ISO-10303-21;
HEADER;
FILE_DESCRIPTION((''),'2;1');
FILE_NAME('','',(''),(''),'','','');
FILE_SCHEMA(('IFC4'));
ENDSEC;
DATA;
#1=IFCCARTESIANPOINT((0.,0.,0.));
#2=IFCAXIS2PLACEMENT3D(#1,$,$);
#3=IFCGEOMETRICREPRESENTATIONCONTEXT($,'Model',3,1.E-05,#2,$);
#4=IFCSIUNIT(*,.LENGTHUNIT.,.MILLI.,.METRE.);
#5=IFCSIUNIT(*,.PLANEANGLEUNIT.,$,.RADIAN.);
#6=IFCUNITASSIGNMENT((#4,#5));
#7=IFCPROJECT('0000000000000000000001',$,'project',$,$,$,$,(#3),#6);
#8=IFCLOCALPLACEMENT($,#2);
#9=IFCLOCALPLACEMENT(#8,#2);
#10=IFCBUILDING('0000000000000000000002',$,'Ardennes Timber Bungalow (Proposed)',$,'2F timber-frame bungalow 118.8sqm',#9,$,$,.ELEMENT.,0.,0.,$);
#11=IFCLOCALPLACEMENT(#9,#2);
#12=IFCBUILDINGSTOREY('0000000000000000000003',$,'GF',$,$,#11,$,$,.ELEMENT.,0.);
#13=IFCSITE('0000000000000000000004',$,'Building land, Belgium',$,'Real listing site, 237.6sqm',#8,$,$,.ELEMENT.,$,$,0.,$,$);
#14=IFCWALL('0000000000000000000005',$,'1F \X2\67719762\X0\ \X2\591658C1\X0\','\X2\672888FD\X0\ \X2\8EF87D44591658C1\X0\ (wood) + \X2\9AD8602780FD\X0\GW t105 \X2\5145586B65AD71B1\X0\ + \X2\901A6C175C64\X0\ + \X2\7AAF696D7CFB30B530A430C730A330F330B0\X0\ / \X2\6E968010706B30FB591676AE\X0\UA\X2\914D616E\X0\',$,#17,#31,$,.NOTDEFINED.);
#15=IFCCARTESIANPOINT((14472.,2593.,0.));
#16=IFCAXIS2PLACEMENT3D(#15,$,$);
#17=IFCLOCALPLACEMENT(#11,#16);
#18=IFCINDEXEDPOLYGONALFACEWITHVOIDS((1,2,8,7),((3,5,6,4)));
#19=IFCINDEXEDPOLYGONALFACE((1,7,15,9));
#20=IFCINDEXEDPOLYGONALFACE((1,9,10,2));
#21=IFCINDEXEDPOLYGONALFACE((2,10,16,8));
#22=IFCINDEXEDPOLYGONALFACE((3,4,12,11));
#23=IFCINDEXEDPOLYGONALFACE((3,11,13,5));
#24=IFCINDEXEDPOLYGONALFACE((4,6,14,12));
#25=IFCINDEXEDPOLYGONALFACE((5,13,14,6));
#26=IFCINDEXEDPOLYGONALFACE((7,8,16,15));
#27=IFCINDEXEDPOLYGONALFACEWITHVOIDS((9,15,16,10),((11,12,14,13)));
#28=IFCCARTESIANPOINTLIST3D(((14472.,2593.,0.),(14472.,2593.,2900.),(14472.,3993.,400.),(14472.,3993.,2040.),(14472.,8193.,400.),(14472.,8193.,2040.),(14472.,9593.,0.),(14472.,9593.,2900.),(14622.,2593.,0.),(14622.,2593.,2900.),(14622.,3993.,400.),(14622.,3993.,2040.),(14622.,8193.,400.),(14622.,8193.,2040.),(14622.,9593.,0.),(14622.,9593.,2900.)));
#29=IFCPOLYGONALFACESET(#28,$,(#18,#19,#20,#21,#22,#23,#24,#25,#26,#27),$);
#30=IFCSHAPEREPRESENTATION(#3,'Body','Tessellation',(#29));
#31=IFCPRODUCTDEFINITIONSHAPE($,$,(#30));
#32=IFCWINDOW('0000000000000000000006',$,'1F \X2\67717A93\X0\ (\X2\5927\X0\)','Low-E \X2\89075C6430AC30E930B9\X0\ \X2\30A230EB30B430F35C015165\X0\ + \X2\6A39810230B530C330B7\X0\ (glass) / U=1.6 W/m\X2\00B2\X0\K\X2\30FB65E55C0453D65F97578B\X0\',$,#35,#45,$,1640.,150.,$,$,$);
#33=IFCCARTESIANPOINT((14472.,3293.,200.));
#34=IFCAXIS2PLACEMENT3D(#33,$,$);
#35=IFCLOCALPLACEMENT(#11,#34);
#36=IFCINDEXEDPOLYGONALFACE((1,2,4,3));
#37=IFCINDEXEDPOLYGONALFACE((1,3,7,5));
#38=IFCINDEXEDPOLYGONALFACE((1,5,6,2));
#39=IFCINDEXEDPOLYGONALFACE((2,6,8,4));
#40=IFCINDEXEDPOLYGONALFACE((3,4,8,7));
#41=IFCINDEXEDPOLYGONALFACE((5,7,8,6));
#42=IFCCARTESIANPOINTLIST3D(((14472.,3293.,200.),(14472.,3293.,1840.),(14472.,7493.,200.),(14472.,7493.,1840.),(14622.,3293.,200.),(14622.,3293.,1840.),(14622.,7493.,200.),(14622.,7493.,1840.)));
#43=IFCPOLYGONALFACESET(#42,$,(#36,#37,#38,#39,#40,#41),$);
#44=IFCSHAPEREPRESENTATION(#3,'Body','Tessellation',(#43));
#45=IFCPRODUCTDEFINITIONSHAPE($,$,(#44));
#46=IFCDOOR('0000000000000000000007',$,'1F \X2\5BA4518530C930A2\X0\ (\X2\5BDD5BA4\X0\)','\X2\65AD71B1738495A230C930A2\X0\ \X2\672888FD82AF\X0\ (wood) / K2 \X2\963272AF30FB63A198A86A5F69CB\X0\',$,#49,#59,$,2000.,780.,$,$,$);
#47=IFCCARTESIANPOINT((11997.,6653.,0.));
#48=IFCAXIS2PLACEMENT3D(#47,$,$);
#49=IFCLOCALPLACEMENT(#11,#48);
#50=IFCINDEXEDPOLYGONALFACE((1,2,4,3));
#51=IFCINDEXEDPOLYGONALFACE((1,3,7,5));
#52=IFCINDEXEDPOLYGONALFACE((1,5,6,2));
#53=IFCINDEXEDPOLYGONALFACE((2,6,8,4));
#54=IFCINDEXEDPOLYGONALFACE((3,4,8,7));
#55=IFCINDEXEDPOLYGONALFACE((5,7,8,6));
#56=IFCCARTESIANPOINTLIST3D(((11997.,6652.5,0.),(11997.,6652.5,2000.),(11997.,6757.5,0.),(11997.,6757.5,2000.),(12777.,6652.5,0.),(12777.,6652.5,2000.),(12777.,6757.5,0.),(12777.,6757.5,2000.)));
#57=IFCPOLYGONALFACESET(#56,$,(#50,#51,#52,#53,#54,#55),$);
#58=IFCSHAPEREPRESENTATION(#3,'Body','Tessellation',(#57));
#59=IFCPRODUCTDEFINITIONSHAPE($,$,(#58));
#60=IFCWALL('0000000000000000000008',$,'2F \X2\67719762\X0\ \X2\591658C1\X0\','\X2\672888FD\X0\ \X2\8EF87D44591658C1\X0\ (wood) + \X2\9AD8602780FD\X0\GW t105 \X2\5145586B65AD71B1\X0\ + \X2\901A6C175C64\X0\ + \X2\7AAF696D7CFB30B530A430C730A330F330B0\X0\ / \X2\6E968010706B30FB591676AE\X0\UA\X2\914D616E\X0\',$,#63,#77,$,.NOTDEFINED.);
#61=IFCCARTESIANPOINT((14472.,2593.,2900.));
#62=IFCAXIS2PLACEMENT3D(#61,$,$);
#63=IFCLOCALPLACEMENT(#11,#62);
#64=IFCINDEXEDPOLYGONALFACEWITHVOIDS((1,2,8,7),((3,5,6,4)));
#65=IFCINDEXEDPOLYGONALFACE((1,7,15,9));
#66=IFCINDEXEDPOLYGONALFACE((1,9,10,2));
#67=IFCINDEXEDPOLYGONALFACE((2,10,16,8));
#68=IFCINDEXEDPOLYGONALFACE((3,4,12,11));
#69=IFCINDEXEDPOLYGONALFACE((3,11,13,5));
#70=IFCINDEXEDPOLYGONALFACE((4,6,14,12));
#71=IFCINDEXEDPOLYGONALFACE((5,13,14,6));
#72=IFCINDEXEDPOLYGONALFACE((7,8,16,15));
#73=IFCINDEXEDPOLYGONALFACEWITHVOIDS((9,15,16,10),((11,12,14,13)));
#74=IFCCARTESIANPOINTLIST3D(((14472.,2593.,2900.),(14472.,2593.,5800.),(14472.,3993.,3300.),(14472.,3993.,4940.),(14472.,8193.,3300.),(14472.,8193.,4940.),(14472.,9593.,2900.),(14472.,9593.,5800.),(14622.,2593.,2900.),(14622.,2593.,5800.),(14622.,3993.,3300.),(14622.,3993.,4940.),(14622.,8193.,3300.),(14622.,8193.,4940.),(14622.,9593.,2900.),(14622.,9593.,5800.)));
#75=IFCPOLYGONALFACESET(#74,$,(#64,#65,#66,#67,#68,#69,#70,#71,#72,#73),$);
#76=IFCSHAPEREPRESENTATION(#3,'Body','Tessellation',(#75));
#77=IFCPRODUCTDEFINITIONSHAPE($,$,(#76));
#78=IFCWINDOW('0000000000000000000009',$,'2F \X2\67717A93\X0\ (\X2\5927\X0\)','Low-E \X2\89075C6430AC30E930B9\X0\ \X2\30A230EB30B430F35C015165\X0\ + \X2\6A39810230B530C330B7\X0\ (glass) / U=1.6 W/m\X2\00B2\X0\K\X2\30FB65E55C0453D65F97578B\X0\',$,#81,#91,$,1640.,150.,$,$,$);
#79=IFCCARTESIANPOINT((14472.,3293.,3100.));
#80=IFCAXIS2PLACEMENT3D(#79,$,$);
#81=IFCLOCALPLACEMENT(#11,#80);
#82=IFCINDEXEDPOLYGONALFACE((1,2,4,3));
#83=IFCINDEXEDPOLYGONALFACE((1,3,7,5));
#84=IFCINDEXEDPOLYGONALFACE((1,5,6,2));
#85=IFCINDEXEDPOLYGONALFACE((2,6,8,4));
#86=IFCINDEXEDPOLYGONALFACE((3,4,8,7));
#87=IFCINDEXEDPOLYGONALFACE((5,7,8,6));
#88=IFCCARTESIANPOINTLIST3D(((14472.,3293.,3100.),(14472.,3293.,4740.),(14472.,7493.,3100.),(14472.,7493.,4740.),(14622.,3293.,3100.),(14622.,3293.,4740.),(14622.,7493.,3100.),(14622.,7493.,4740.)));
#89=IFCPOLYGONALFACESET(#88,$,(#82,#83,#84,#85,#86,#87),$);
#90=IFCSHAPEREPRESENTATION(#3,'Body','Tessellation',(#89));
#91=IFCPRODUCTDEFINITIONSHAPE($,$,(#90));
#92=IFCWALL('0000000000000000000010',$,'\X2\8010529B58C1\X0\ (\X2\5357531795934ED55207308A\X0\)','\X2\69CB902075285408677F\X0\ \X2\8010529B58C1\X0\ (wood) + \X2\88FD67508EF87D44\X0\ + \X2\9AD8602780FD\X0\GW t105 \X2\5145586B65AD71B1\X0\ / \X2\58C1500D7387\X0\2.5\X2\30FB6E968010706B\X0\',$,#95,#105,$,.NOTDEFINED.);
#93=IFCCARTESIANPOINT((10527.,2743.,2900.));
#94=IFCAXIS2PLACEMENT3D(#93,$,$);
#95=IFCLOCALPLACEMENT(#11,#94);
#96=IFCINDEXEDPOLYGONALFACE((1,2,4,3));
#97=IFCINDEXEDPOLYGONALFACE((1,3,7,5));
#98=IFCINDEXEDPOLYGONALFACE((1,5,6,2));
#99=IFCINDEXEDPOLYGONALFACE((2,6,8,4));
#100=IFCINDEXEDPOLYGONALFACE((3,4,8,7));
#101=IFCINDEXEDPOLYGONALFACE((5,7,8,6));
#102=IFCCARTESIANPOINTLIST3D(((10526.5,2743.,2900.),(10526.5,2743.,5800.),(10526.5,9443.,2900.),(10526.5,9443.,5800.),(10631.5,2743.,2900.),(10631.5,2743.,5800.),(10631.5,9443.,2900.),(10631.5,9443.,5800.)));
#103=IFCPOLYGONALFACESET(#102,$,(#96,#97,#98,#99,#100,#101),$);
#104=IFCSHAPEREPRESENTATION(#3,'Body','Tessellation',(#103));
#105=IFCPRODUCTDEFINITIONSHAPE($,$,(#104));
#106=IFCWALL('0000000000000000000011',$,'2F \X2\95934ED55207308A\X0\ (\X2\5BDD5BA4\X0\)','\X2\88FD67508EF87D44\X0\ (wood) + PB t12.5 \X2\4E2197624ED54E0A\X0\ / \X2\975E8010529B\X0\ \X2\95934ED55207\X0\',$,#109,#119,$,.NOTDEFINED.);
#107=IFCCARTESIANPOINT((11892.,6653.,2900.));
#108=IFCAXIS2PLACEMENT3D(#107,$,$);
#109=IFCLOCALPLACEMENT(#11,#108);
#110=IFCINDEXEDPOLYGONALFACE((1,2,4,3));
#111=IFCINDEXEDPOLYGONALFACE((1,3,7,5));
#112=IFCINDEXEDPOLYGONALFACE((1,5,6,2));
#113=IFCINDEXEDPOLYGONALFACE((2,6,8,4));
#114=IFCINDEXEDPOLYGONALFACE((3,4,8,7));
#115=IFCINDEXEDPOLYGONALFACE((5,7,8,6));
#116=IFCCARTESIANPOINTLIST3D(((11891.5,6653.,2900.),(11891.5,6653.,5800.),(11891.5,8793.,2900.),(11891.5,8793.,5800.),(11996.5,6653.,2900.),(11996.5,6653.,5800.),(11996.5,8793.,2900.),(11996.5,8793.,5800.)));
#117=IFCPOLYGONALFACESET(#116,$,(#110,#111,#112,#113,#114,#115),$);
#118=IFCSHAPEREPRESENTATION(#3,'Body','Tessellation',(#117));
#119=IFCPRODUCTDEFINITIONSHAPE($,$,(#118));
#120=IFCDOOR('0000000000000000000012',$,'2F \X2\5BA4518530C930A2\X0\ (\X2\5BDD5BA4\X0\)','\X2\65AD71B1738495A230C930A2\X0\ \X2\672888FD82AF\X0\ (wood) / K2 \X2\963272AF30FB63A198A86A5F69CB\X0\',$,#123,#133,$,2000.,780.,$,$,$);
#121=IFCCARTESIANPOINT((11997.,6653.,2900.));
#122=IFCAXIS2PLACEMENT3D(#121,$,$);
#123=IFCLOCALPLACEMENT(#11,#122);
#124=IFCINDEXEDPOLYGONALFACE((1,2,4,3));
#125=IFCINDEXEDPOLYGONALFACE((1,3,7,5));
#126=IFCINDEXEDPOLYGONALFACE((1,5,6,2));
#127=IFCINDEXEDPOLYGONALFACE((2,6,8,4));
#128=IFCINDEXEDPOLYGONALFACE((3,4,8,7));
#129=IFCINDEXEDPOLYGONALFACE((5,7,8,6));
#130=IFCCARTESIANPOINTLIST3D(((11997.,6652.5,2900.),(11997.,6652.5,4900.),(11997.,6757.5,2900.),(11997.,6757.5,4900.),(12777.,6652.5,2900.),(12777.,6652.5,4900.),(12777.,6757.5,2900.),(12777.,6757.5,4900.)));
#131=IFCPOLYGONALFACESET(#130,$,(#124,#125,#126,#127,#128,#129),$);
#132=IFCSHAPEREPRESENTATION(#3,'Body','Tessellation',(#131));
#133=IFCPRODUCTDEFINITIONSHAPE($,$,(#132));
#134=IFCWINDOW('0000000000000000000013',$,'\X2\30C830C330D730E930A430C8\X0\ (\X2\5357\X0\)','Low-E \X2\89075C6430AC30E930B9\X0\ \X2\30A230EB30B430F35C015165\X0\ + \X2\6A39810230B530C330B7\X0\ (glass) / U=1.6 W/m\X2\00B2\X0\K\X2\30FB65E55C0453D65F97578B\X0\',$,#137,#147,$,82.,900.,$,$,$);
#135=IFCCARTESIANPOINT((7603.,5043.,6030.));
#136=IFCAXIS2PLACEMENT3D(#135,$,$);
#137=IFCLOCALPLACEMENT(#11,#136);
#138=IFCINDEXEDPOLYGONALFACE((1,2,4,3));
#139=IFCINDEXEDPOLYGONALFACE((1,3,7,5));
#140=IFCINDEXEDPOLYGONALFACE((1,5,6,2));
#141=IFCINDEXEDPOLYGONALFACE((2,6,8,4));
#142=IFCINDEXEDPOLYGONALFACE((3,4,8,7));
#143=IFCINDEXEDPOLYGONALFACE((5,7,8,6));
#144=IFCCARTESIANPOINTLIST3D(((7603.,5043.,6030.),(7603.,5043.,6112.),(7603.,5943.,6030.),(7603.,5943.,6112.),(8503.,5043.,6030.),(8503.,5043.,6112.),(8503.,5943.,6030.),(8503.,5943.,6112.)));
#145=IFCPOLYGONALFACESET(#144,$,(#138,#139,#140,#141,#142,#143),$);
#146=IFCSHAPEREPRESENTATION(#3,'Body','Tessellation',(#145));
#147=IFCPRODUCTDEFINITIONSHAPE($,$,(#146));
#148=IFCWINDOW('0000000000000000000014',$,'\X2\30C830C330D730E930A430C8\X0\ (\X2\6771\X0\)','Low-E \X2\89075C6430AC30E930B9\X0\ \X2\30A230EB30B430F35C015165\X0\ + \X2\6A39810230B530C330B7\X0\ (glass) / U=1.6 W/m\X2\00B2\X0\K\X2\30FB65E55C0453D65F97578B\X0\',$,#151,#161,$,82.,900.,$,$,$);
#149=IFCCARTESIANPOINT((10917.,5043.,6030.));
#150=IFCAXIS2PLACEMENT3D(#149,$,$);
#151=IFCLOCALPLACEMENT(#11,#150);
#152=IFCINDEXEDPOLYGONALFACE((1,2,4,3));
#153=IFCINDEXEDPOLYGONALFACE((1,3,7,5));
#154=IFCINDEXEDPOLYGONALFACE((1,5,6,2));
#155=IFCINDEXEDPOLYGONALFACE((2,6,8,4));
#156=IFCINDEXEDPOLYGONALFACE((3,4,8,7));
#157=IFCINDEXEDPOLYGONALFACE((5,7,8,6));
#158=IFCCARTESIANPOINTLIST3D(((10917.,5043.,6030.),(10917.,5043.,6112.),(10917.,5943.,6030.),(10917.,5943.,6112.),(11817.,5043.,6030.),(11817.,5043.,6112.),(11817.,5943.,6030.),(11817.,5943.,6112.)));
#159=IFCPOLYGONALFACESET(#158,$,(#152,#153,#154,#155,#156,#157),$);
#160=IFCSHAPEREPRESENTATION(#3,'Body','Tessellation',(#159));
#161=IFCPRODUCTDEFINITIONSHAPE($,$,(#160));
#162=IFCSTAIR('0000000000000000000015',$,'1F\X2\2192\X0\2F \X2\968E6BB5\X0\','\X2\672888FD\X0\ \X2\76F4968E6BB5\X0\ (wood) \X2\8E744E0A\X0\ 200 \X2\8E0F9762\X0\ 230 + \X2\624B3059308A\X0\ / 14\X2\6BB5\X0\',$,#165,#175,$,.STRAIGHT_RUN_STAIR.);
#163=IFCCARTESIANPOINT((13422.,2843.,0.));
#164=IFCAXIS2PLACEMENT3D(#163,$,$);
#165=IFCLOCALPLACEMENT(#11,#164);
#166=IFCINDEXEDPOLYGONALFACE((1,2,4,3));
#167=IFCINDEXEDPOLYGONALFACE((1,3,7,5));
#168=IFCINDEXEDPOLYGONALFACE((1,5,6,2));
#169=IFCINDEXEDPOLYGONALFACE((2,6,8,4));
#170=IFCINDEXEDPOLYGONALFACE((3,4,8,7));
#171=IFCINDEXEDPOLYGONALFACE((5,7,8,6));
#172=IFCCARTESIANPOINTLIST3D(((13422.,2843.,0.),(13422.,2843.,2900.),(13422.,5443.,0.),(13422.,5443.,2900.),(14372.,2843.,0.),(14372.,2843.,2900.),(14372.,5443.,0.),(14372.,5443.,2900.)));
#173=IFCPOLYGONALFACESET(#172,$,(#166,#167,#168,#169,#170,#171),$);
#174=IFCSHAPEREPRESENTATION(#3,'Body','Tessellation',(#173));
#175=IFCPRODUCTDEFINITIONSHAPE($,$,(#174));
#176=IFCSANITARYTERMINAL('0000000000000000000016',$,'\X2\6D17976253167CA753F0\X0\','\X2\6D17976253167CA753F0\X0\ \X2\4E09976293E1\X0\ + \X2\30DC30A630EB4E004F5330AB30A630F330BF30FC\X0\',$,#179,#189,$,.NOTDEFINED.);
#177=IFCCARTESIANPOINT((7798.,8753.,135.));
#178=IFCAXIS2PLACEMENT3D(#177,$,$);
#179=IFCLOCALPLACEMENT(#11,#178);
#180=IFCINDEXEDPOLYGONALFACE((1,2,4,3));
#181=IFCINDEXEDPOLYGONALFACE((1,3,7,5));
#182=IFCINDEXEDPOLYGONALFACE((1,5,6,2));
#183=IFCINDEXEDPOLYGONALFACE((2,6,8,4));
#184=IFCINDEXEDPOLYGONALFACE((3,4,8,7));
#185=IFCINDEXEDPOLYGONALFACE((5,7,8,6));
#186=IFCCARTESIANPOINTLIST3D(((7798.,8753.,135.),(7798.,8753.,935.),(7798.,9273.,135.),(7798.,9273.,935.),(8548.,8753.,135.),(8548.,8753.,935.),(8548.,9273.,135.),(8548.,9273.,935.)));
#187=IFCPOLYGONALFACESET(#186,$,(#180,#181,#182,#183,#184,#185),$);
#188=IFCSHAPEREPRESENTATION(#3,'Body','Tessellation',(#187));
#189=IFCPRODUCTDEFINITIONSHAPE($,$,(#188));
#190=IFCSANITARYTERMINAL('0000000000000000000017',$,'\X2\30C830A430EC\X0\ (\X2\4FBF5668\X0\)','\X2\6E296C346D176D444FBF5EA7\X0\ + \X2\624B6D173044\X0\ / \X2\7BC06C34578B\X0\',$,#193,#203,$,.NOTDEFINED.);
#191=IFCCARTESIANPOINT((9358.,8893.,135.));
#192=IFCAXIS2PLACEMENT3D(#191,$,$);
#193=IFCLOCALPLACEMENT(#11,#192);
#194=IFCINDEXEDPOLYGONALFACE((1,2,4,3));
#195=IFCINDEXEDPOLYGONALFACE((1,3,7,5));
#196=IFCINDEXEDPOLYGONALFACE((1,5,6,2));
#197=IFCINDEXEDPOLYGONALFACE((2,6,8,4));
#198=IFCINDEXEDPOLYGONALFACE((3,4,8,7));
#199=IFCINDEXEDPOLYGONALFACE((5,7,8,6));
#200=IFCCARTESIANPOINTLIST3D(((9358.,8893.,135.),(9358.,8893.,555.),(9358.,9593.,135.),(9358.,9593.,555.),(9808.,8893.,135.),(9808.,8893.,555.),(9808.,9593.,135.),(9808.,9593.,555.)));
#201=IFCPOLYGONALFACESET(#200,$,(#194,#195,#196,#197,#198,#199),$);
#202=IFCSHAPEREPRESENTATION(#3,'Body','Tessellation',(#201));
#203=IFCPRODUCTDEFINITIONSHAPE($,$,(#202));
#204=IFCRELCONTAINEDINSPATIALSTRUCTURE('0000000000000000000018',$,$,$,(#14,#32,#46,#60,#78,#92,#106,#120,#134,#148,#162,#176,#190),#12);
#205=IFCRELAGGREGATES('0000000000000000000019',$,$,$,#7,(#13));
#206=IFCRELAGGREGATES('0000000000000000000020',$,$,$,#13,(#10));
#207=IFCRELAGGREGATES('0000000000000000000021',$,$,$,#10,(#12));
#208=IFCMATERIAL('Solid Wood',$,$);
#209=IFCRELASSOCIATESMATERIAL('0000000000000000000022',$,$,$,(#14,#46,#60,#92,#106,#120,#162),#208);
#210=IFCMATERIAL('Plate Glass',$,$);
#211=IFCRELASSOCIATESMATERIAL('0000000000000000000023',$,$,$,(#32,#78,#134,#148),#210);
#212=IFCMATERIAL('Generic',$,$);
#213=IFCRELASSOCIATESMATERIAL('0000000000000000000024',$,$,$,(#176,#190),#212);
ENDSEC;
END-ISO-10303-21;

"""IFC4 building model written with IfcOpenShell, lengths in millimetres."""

from ifc_helpers import new_model, si_unit, frame, frame_2d, origin, place, context, project, spatial, rectangle, extrude, material, element, fill, save


model = new_model("IFC4")

# Units and contexts
model_context = context("Model", 3, precision=1e-05, world=origin())
ifc_project = project(units=[si_unit("LENGTHUNIT", "METRE", prefix="MILLI"), si_unit("PLANEANGLEUNIT", "RADIAN")], contexts=[model_context])

# Site, building, storey
site_placement = place(None, origin())
site = spatial("IfcSite", under=ifc_project, at=site_placement, Name="Building land, Belgium", ObjectType="Real listing site, 237.6sqm", CompositionType="ELEMENT", RefElevation=0.0)
building_placement = place(site_placement, origin())
building = spatial("IfcBuilding", under=site, at=building_placement, Name="Ardennes Timber Bungalow (Proposed)", ObjectType="2F timber-frame bungalow 118.8sqm", CompositionType="ELEMENT", ElevationOfRefHeight=0.0, ElevationOfTerrain=0.0)
storey_placement = place(building_placement, origin())
storey = spatial("IfcBuildingStorey", under=building, at=storey_placement, Name="GF", CompositionType="ELEMENT", Elevation=0.0)

# Wall, opening, window
ifc_material_1 = material(Name="Solid Wood")
wall_1_placement = place(storey_placement, frame((14472.0, 2593.0, 0.0)))
wall_1 = element("IfcWall", 1, at=wall_1_placement, inside=storey, material=ifc_material_1, Name="1F 東面 外壁", Description="木製 軸組外壁 (wood) + 高性能GW t105 充填断熱 + 通気層 + 窯業系サイディング / 準耐火・外皮UA配慮", PredefinedType="NOTDEFINED", context=model_context, shape_type="SweptSolid", body=[
    extrude(rectangle(XDim=150.0, YDim=7000.0, at=frame_2d((75.0, 3500.0))), frame((14472.0, 2593.0, 0.0)), (0.0, 0.0, 1.0), 2900.0),
])
opening_1_placement = place(storey_placement, frame((14472.0, 3293.0, 200.0)))
opening_1 = element("IfcOpeningElement", 2, at=opening_1_placement, cuts=wall_1, PredefinedType="NOTDEFINED", context=model_context, shape_type="SweptSolid", body=[
    extrude(rectangle(XDim=150.0, YDim=4200.0, at=frame_2d((75.0, 2100.0))), frame((14472.0, 3293.0, 200.0)), (0.0, 0.0, 1.0), 1640.0),
])
ifc_material_2 = material(Name="Plate Glass")
window_1_placement = place(storey_placement, frame((14472.0, 3293.0, 200.0)))
window_1 = element("IfcWindow", 3, at=window_1_placement, inside=storey, material=ifc_material_2, Name="1F 東窓 (大)", Description="Low-E 複層ガラス アルゴン封入 + 樹脂サッシ (glass) / U=1.6 W/m²K・日射取得型", OverallHeight=1640.0, OverallWidth=150.0, context=model_context, shape_type="SweptSolid", body=[
    extrude(rectangle(XDim=150.0, YDim=4200.0, at=frame_2d((75.0, 2100.0))), frame((14472.0, 3293.0, 200.0)), (0.0, 0.0, 1.0), 1640.0),
])
fill(opening_1, window_1)

# Door
door_1_placement = place(storey_placement, frame((11997.0, 6653.0, 0.0)))
element("IfcDoor", 4, at=door_1_placement, inside=storey, material=ifc_material_1, Name="1F 室内ドア (寝室)", Description="断熱玄関ドア 木製芯 (wood) / K2 防犯・採風機構", OverallHeight=2000.0, OverallWidth=780.0, context=model_context, shape_type="SweptSolid", body=[
    extrude(rectangle(XDim=780.0, YDim=105.0, at=frame_2d((390.0, 52.0))), frame((11997.0, 6653.0, 0.0)), (0.0, 0.0, 1.0), 2000.0),
])

# Wall, opening, window
wall_2_placement = place(storey_placement, frame((14472.0, 2593.0, 2900.0)))
wall_2 = element("IfcWall", 5, at=wall_2_placement, inside=storey, material=ifc_material_1, Name="2F 東面 外壁", Description="木製 軸組外壁 (wood) + 高性能GW t105 充填断熱 + 通気層 + 窯業系サイディング / 準耐火・外皮UA配慮", PredefinedType="NOTDEFINED", context=model_context, shape_type="SweptSolid", body=[
    extrude(rectangle(XDim=150.0, YDim=7000.0, at=frame_2d((75.0, 3500.0))), frame((14472.0, 2593.0, 2900.0)), (0.0, 0.0, 1.0), 2900.0),
])
opening_2_placement = place(storey_placement, frame((14472.0, 3293.0, 3100.0)))
opening_2 = element("IfcOpeningElement", 6, at=opening_2_placement, cuts=wall_2, PredefinedType="NOTDEFINED", context=model_context, shape_type="SweptSolid", body=[
    extrude(rectangle(XDim=150.0, YDim=4200.0, at=frame_2d((75.0, 2100.0))), frame((14472.0, 3293.0, 3100.0)), (0.0, 0.0, 1.0), 1640.0),
])
window_2_placement = place(storey_placement, frame((14472.0, 3293.0, 3100.0)))
window_2 = element("IfcWindow", 7, at=window_2_placement, inside=storey, material=ifc_material_2, Name="2F 東窓 (大)", Description="Low-E 複層ガラス アルゴン封入 + 樹脂サッシ (glass) / U=1.6 W/m²K・日射取得型", OverallHeight=1640.0, OverallWidth=150.0, context=model_context, shape_type="SweptSolid", body=[
    extrude(rectangle(XDim=150.0, YDim=4200.0, at=frame_2d((75.0, 2100.0))), frame((14472.0, 3293.0, 3100.0)), (0.0, 0.0, 1.0), 1640.0),
])
fill(opening_2, window_2)

# Walls
wall_3_placement = place(storey_placement, frame((10527.0, 2743.0, 2900.0)))
element("IfcWall", 8, at=wall_3_placement, inside=storey, material=ifc_material_1, Name="耐力壁 (南北間仕切り)", Description="構造用合板 耐力壁 (wood) + 製材軸組 + 高性能GW t105 充填断熱 / 壁倍率2.5・準耐火", PredefinedType="NOTDEFINED", context=model_context, shape_type="SweptSolid", body=[
    extrude(rectangle(XDim=105.0, YDim=6700.0, at=frame_2d((52.0, 3350.0))), frame((10527.0, 2743.0, 2900.0)), (0.0, 0.0, 1.0), 2900.0),
])
wall_4_placement = place(storey_placement, frame((11892.0, 6653.0, 2900.0)))
element("IfcWall", 9, at=wall_4_placement, inside=storey, material=ifc_material_1, Name="2F 間仕切り (寝室)", Description="製材軸組 (wood) + PB t12.5 両面仕上 / 非耐力 間仕切", PredefinedType="NOTDEFINED", context=model_context, shape_type="SweptSolid", body=[
    extrude(rectangle(XDim=105.0, YDim=2140.0, at=frame_2d((52.0, 1070.0))), frame((11892.0, 6653.0, 2900.0)), (0.0, 0.0, 1.0), 2900.0),
])

# Door
door_2_placement = place(storey_placement, frame((11997.0, 6653.0, 2900.0)))
element("IfcDoor", 10, at=door_2_placement, inside=storey, material=ifc_material_1, Name="2F 室内ドア (寝室)", Description="断熱玄関ドア 木製芯 (wood) / K2 防犯・採風機構", OverallHeight=2000.0, OverallWidth=780.0, context=model_context, shape_type="SweptSolid", body=[
    extrude(rectangle(XDim=780.0, YDim=105.0, at=frame_2d((390.0, 52.0))), frame((11997.0, 6653.0, 2900.0)), (0.0, 0.0, 1.0), 2000.0),
])

# Windows
window_3_placement = place(storey_placement, frame((7603.0, 5043.0, 6030.0)))
element("IfcWindow", 11, at=window_3_placement, inside=storey, material=ifc_material_2, Name="トップライト (南)", Description="Low-E 複層ガラス アルゴン封入 + 樹脂サッシ (glass) / U=1.6 W/m²K・日射取得型", OverallHeight=82.0, OverallWidth=900.0, context=model_context, shape_type="SweptSolid", body=[
    extrude(rectangle(XDim=900.0, YDim=900.0, at=frame_2d((450.0, 450.0))), frame((7603.0, 5043.0, 6030.0)), (0.0, 0.0, 1.0), 82.0),
])
window_4_placement = place(storey_placement, frame((10917.0, 5043.0, 6030.0)))
element("IfcWindow", 12, at=window_4_placement, inside=storey, material=ifc_material_2, Name="トップライト (東)", Description="Low-E 複層ガラス アルゴン封入 + 樹脂サッシ (glass) / U=1.6 W/m²K・日射取得型", OverallHeight=82.0, OverallWidth=900.0, context=model_context, shape_type="SweptSolid", body=[
    extrude(rectangle(XDim=900.0, YDim=900.0, at=frame_2d((450.0, 450.0))), frame((10917.0, 5043.0, 6030.0)), (0.0, 0.0, 1.0), 82.0),
])

# Stair
stair_placement = place(storey_placement, frame((13422.0, 2843.0, 0.0)))
element("IfcStair", 13, at=stair_placement, inside=storey, material=ifc_material_1, Name="1F→2F 階段", Description="木製 直階段 (wood) 蹴上 200 踏面 230 + 手すり / 14段", PredefinedType="STRAIGHT_RUN_STAIR", context=model_context, shape_type="SweptSolid", body=[
    extrude(rectangle(XDim=950.0, YDim=2600.0, at=frame_2d((475.0, 1300.0))), frame((13422.0, 2843.0, 0.0)), (0.0, 0.0, 1.0), 2900.0),
])

# Sanitary terminals
ifc_material_3 = material(Name="Generic")
sanitary_terminal_1_placement = place(storey_placement, frame((7798.0, 8753.0, 135.0)))
element("IfcSanitaryTerminal", 14, at=sanitary_terminal_1_placement, inside=storey, material=ifc_material_3, Name="洗面化粧台", Description="洗面化粧台 三面鏡 + ボウル一体カウンター", PredefinedType="NOTDEFINED", context=model_context, shape_type="SweptSolid", body=[
    extrude(rectangle(XDim=750.0, YDim=520.0, at=frame_2d((375.0, 260.0))), frame((7798.0, 8753.0, 135.0)), (0.0, 0.0, 1.0), 800.0),
])
sanitary_terminal_2_placement = place(storey_placement, frame((9358.0, 8893.0, 135.0)))
element("IfcSanitaryTerminal", 15, at=sanitary_terminal_2_placement, inside=storey, material=ifc_material_3, Name="トイレ (便器)", Description="温水洗浄便座 + 手洗い / 節水型", PredefinedType="NOTDEFINED", context=model_context, shape_type="SweptSolid", body=[
    extrude(rectangle(XDim=450.0, YDim=700.0, at=frame_2d((225.0, 350.0))), frame((9358.0, 8893.0, 135.0)), (0.0, 0.0, 1.0), 420.0),
])

save(model, "model.ifc")
